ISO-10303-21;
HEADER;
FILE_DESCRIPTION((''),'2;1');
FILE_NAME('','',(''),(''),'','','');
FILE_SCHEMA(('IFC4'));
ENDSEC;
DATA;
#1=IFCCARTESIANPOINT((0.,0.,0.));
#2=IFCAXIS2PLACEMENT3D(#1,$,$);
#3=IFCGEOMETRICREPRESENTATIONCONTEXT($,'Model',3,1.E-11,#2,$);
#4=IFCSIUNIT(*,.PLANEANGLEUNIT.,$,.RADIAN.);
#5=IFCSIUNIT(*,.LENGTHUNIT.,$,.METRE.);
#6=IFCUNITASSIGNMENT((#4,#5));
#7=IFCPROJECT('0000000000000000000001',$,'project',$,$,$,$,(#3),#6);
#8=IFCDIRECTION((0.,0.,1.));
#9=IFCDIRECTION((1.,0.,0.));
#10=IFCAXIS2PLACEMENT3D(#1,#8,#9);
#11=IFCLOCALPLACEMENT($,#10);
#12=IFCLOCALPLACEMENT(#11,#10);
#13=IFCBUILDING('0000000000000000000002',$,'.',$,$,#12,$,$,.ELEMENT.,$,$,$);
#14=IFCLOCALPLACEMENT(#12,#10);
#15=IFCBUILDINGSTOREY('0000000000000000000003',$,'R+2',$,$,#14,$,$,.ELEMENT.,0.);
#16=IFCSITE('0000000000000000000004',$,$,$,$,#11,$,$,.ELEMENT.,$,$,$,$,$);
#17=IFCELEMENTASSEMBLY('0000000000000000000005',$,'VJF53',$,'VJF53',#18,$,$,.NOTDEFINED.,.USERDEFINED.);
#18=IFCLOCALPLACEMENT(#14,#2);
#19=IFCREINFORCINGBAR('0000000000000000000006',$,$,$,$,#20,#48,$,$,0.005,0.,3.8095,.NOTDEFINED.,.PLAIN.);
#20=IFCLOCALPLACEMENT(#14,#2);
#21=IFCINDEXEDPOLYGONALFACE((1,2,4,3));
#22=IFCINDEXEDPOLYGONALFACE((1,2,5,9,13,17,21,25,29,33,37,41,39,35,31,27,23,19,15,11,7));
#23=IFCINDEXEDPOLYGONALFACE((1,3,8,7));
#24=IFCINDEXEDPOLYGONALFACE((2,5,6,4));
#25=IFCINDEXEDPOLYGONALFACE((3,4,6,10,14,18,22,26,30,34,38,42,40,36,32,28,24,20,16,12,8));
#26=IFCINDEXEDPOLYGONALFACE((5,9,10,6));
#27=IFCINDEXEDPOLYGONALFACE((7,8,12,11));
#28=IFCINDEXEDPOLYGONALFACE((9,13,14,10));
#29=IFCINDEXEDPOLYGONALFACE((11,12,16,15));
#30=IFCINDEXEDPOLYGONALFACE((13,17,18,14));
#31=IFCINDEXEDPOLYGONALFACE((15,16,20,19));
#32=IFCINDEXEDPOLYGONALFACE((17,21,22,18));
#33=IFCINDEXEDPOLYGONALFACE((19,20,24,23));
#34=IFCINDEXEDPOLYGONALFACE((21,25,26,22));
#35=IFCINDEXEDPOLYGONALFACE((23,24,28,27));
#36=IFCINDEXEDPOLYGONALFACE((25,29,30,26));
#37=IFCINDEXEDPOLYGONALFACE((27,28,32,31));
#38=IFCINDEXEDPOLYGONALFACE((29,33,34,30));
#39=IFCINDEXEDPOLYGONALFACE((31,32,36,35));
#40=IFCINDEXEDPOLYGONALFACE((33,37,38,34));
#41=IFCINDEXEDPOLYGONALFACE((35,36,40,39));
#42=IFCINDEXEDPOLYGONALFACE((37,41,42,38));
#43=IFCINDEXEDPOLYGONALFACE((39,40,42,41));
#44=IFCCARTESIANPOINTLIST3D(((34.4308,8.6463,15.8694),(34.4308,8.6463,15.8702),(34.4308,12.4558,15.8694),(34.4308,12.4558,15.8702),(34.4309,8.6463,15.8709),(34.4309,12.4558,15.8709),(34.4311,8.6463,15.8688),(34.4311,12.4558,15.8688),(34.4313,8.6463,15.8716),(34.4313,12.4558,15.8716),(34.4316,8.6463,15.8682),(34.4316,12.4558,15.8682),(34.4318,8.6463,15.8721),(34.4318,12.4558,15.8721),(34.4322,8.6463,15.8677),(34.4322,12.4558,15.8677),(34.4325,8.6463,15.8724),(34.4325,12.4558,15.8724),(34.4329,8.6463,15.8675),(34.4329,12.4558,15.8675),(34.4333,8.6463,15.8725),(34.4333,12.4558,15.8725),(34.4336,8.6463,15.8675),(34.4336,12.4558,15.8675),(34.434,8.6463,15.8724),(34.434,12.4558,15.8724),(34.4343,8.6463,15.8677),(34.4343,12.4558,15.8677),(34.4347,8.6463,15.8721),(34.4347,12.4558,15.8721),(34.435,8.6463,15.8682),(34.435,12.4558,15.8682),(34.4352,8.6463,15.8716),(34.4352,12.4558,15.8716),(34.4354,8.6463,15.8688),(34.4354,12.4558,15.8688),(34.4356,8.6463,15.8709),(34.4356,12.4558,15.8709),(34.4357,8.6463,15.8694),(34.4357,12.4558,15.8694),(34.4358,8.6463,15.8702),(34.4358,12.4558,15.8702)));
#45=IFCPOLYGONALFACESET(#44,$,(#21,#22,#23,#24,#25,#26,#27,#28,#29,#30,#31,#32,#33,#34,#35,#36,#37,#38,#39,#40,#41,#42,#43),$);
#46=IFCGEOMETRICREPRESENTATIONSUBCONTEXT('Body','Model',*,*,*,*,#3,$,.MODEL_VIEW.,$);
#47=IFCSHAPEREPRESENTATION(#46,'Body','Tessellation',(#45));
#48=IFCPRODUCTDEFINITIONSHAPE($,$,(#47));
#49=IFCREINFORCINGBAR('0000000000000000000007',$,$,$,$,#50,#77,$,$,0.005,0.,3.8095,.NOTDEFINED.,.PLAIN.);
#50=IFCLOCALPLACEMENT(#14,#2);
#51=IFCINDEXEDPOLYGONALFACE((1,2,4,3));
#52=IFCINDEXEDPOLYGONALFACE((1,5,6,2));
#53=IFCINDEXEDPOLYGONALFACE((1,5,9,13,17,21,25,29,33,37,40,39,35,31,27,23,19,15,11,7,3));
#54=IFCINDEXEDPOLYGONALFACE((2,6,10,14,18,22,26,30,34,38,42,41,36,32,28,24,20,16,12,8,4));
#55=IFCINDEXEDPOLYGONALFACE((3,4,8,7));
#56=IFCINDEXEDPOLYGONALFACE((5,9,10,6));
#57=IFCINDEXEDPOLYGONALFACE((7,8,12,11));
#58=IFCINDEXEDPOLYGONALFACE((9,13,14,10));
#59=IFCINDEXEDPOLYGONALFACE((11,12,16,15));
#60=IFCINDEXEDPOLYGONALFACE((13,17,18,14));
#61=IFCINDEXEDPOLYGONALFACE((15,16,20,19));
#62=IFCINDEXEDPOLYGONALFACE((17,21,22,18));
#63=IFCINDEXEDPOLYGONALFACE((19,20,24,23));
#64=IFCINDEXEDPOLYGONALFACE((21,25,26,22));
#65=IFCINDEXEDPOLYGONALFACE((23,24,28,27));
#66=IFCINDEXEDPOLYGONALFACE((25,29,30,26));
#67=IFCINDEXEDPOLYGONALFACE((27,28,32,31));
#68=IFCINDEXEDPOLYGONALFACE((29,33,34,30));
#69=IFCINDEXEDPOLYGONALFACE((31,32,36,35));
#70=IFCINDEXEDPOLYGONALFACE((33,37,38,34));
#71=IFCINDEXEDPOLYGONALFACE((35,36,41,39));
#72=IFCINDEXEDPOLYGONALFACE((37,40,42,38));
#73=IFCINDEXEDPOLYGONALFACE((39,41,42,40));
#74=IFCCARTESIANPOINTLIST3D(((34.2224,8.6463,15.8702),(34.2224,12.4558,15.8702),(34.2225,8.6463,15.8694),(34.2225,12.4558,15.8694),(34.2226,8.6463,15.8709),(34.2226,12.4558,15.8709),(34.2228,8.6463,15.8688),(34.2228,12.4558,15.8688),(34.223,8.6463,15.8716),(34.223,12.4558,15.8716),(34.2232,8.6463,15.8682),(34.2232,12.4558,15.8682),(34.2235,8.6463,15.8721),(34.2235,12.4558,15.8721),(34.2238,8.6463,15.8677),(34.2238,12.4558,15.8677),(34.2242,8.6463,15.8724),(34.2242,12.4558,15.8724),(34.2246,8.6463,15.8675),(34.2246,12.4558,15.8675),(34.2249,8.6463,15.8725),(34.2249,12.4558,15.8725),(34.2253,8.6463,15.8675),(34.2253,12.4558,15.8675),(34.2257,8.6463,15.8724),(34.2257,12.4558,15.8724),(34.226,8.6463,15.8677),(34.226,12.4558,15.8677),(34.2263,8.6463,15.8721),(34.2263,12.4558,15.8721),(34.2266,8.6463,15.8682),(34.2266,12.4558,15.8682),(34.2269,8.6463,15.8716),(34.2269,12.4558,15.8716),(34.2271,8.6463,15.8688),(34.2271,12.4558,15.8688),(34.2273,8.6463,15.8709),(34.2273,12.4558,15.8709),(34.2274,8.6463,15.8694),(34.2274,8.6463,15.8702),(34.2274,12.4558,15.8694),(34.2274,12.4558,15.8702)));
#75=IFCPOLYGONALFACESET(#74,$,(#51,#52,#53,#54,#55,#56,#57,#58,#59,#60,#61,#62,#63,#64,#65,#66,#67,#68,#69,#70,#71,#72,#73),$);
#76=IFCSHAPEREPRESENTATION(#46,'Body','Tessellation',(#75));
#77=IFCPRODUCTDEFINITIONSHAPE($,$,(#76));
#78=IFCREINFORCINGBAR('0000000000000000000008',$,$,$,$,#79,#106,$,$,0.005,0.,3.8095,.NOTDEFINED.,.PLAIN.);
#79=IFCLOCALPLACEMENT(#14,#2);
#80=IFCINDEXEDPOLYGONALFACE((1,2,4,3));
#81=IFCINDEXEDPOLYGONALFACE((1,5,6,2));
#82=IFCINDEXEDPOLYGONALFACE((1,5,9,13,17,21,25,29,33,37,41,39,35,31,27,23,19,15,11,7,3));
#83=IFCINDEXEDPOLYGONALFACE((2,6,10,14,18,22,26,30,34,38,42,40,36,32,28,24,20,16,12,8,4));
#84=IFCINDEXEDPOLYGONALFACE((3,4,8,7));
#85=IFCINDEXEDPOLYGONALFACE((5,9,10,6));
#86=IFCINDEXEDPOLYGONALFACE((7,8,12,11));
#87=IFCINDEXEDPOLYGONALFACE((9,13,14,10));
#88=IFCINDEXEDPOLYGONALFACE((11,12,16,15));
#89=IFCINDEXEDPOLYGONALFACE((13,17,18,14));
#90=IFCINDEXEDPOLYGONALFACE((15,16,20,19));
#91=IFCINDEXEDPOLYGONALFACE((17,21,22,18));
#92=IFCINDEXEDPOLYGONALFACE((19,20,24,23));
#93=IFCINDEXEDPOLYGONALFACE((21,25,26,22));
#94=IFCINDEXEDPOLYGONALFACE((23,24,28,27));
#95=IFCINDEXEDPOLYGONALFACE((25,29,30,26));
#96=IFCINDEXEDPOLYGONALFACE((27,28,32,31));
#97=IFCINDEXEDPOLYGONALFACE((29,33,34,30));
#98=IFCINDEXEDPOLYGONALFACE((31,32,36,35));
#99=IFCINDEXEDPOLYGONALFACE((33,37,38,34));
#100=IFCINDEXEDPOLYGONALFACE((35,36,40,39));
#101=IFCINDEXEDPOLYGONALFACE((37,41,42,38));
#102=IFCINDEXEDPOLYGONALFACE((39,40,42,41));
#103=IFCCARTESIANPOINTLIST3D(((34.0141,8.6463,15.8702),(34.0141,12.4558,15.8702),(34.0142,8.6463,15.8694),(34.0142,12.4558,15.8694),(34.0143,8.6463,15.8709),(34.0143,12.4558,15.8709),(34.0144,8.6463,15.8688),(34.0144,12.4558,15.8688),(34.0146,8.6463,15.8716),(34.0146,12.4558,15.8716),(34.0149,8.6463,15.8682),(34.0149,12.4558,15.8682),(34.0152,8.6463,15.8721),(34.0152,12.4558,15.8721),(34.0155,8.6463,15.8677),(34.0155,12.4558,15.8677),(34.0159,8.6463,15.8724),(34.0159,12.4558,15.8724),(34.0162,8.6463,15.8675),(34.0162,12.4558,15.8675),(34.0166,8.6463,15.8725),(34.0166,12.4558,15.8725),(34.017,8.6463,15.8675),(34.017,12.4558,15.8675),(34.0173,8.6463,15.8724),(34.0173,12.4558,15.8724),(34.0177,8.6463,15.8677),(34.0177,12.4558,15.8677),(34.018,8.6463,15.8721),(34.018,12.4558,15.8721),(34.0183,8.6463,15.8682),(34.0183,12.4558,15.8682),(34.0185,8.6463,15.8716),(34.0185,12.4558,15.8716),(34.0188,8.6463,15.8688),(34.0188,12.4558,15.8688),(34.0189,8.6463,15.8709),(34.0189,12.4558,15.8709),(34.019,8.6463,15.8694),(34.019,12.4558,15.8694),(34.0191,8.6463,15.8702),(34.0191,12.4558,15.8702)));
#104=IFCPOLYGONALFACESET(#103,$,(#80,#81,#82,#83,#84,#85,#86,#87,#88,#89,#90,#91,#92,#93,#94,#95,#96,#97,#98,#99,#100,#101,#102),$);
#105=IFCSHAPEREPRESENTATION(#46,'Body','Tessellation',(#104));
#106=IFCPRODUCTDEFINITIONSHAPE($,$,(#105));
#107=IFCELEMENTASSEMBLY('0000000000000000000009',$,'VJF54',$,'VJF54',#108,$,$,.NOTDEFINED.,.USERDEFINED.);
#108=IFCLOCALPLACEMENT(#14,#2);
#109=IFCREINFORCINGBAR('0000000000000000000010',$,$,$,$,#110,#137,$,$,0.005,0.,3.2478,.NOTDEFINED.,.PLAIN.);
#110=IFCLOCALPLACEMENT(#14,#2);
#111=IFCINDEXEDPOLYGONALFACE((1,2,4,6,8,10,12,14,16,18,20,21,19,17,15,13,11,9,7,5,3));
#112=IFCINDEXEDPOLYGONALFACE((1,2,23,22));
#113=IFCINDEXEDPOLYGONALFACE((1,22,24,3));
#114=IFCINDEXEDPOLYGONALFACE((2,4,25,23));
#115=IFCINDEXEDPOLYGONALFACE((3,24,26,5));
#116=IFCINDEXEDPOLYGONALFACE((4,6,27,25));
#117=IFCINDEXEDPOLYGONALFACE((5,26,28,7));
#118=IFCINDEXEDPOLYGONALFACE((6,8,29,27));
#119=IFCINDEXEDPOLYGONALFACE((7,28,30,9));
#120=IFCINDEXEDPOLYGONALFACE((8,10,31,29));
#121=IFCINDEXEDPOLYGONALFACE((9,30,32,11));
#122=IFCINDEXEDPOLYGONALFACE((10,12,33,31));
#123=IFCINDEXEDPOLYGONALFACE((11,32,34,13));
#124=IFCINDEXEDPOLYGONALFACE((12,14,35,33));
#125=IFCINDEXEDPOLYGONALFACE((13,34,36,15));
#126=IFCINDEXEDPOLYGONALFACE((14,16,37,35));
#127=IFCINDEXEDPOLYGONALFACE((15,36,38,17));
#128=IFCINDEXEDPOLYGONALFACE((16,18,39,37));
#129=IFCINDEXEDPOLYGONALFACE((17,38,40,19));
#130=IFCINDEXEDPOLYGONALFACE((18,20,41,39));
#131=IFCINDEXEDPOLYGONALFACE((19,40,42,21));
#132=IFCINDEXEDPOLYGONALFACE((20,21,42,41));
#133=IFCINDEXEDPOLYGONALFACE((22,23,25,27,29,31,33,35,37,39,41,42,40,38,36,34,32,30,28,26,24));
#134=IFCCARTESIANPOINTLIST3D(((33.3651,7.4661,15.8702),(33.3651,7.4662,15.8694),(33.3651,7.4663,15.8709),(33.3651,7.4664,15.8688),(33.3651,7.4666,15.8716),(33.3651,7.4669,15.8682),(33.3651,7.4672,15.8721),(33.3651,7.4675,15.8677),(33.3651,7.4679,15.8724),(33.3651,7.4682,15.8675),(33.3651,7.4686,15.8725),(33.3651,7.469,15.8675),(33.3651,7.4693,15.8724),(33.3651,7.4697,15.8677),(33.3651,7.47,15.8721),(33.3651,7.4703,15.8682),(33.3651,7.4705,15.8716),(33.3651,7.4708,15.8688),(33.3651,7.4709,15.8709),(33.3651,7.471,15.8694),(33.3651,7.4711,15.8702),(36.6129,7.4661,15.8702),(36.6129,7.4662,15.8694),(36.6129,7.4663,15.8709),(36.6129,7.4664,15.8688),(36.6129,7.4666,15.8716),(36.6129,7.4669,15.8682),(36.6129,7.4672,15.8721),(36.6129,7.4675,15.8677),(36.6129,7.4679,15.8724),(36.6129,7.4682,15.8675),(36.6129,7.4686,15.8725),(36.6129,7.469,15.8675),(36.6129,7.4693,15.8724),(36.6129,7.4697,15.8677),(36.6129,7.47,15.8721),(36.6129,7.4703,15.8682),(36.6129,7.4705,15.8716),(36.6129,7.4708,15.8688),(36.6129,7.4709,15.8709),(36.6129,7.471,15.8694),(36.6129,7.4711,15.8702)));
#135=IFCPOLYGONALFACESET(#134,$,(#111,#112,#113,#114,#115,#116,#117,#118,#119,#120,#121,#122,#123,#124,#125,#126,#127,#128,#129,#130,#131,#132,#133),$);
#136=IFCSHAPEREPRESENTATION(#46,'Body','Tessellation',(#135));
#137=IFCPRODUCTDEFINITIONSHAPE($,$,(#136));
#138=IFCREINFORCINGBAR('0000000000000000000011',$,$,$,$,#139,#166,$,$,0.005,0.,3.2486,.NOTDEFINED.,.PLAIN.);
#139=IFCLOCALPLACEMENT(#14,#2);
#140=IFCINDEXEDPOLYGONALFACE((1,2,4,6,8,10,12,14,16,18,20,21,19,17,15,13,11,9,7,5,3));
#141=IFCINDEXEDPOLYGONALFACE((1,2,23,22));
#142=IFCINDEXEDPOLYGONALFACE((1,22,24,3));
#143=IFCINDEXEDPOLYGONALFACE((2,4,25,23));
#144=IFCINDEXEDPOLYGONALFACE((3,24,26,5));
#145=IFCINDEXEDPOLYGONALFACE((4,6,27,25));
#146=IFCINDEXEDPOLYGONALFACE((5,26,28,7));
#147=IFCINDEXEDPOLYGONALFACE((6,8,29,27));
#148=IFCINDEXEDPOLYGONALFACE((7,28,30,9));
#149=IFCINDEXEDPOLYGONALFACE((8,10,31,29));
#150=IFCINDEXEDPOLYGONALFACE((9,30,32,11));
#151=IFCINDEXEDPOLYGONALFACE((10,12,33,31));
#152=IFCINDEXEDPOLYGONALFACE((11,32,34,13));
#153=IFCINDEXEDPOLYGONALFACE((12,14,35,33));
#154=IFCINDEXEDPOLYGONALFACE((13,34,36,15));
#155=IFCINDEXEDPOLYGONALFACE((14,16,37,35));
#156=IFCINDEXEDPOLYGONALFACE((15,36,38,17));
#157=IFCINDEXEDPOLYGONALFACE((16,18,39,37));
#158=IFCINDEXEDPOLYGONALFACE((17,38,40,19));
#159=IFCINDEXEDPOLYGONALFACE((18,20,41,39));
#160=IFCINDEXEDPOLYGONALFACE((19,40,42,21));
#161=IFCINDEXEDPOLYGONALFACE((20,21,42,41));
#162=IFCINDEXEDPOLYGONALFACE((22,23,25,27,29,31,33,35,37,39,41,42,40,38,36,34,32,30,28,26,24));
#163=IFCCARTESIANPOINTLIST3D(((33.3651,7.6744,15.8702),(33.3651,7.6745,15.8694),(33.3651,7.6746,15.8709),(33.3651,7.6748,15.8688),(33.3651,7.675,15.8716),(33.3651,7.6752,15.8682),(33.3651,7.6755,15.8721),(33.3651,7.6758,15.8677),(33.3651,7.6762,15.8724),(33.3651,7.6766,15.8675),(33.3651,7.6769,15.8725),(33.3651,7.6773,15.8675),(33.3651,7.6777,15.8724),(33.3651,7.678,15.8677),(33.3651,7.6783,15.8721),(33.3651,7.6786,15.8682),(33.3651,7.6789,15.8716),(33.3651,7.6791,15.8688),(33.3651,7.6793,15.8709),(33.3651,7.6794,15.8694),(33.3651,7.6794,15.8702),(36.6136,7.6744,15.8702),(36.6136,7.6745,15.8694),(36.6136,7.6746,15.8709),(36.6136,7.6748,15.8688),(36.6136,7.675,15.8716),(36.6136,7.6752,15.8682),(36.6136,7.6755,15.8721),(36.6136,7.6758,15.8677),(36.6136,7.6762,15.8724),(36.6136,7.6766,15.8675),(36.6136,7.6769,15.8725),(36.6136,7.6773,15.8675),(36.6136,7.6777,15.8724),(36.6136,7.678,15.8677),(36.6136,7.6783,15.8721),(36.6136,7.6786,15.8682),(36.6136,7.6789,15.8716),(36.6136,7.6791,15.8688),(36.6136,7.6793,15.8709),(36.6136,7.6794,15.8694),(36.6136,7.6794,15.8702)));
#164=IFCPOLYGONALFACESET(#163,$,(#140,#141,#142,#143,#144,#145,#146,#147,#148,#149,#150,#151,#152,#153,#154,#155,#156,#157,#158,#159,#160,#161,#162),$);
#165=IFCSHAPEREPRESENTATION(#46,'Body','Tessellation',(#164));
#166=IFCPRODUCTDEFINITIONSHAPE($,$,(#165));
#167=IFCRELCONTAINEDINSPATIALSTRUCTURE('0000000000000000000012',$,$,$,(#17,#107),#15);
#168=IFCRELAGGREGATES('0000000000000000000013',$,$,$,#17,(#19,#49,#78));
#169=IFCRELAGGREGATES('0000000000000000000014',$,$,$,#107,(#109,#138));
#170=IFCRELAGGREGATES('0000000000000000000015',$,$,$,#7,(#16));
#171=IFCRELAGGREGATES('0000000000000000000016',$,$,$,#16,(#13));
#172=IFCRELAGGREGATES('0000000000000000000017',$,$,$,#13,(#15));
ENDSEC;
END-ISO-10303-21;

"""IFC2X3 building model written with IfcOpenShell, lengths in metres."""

from ifc_helpers import new_model, entity, si_unit, origin, origin_with_axes, place, context, subcontext, project, spatial, shape, element, aggregate, save


model = new_model("IFC2X3")

# Units and contexts
model_context = context("Model", 3, precision=1e-11, world=origin())
body_context = subcontext(model_context, "Body", "Model", "MODEL_VIEW")
ifc_project = project(units=[si_unit("PLANEANGLEUNIT", "RADIAN"), si_unit("LENGTHUNIT", "METRE")], contexts=[model_context])

# Site, building, storey
site_placement = place(None, origin_with_axes())
site = spatial("IfcSite", under=ifc_project, at=site_placement, CompositionType="ELEMENT")
building_placement = place(site_placement, origin_with_axes())
building = spatial("IfcBuilding", under=site, at=building_placement, Name=".", CompositionType="ELEMENT")
storey_placement = place(building_placement, origin_with_axes())
storey = spatial("IfcBuildingStorey", under=building, at=storey_placement, Name="R+2", CompositionType="ELEMENT", Elevation=0.0)

# Element assemblies, reinforcing bars
assembly_1_placement = place(storey_placement, origin_with_axes())
assembly_1 = element("IfcElementAssembly", 1, at=assembly_1_placement, inside=storey, Name="VJF53", ObjectType="VJF53", AssemblyPlace="NOTDEFINED", PredefinedType="USERDEFINED")
reinforcing_bar_1_placement = place(assembly_1_placement, origin_with_axes())
reinforcing_bar_1 = element("IfcReinforcingBar", 2, at=reinforcing_bar_1_placement, BarLength=3.8095, BarRole="NOTDEFINED", BarSurface="PLAIN", CrossSectionArea=0.0, NominalDiameter=0.005, shapes=[
    shape(body_context, "Body", "AdvancedSweptSolid", [entity("IfcSweptDiskSolid", entity("IfcPolyline", [entity("IfcCartesianPoint", [34.4333, 8.6463, 15.87]), entity("IfcCartesianPoint", [34.4333, 12.4558, 15.87])]), 0.0025, None, 0.0, 3.8095)]),
    shape(body_context, "Body", "AdvancedSweptSolid", [entity("IfcSweptDiskSolid", entity("IfcPolyline", [entity("IfcCartesianPoint", [34.4333, 8.6463, 15.87]), entity("IfcCartesianPoint", [34.4333, 12.4558, 15.87])]), 0.0025, None, 0.0, 3.8095)]),
])
reinforcing_bar_2_placement = place(assembly_1_placement, origin_with_axes())
reinforcing_bar_2 = element("IfcReinforcingBar", 3, at=reinforcing_bar_2_placement, BarLength=3.8095, BarRole="NOTDEFINED", BarSurface="PLAIN", CrossSectionArea=0.0, NominalDiameter=0.005, shapes=[
    shape(body_context, "Body", "AdvancedSweptSolid", [entity("IfcSweptDiskSolid", entity("IfcPolyline", [entity("IfcCartesianPoint", [34.2249, 8.6463, 15.87]), entity("IfcCartesianPoint", [34.2249, 12.4558, 15.87])]), 0.0025, None, 0.0, 3.8095)]),
    shape(body_context, "Body", "AdvancedSweptSolid", [entity("IfcSweptDiskSolid", entity("IfcPolyline", [entity("IfcCartesianPoint", [34.2249, 8.6463, 15.87]), entity("IfcCartesianPoint", [34.2249, 12.4558, 15.87])]), 0.0025, None, 0.0, 3.8095)]),
])
reinforcing_bar_3_placement = place(assembly_1_placement, origin_with_axes())
reinforcing_bar_3 = element("IfcReinforcingBar", 4, at=reinforcing_bar_3_placement, BarLength=3.8095, BarRole="NOTDEFINED", BarSurface="PLAIN", CrossSectionArea=0.0, NominalDiameter=0.005, shapes=[
    shape(body_context, "Body", "AdvancedSweptSolid", [entity("IfcSweptDiskSolid", entity("IfcPolyline", [entity("IfcCartesianPoint", [34.0166, 8.6463, 15.87]), entity("IfcCartesianPoint", [34.0166, 12.4558, 15.87])]), 0.0025, None, 0.0, 3.8095)]),
    shape(body_context, "Body", "AdvancedSweptSolid", [entity("IfcSweptDiskSolid", entity("IfcPolyline", [entity("IfcCartesianPoint", [34.0166, 8.6463, 15.87]), entity("IfcCartesianPoint", [34.0166, 12.4558, 15.87])]), 0.0025, None, 0.0, 3.8095)]),
])
aggregate(assembly_1, [reinforcing_bar_1, reinforcing_bar_2, reinforcing_bar_3])
assembly_2_placement = place(storey_placement, origin_with_axes())
assembly_2 = element("IfcElementAssembly", 5, at=assembly_2_placement, inside=storey, Name="VJF54", ObjectType="VJF54", AssemblyPlace="NOTDEFINED", PredefinedType="USERDEFINED")
reinforcing_bar_4_placement = place(assembly_2_placement, origin_with_axes())
reinforcing_bar_4 = element("IfcReinforcingBar", 6, at=reinforcing_bar_4_placement, BarLength=3.2478, BarRole="NOTDEFINED", BarSurface="PLAIN", CrossSectionArea=0.0, NominalDiameter=0.005, shapes=[
    shape(body_context, "Body", "AdvancedSweptSolid", [entity("IfcSweptDiskSolid", entity("IfcPolyline", [entity("IfcCartesianPoint", [33.3651, 7.4686, 15.87]), entity("IfcCartesianPoint", [36.6129, 7.4686, 15.87])]), 0.0025, None, 0.0, 3.2478)]),
    shape(body_context, "Body", "AdvancedSweptSolid", [entity("IfcSweptDiskSolid", entity("IfcPolyline", [entity("IfcCartesianPoint", [33.3651, 7.4686, 15.87]), entity("IfcCartesianPoint", [36.6129, 7.4686, 15.87])]), 0.0025, None, 0.0, 3.2478)]),
])
reinforcing_bar_5_placement = place(assembly_2_placement, origin_with_axes())
reinforcing_bar_5 = element("IfcReinforcingBar", 7, at=reinforcing_bar_5_placement, BarLength=3.2486, BarRole="NOTDEFINED", BarSurface="PLAIN", CrossSectionArea=0.0, NominalDiameter=0.005, shapes=[
    shape(body_context, "Body", "AdvancedSweptSolid", [entity("IfcSweptDiskSolid", entity("IfcPolyline", [entity("IfcCartesianPoint", [33.3651, 7.6769, 15.87]), entity("IfcCartesianPoint", [36.6136, 7.6769, 15.87])]), 0.0025, None, 0.0, 3.2486)]),
    shape(body_context, "Body", "AdvancedSweptSolid", [entity("IfcSweptDiskSolid", entity("IfcPolyline", [entity("IfcCartesianPoint", [33.3651, 7.6769, 15.87]), entity("IfcCartesianPoint", [36.6136, 7.6769, 15.87])]), 0.0025, None, 0.0, 3.2486)]),
])
aggregate(assembly_2, [reinforcing_bar_4, reinforcing_bar_5])

save(model, "model.ifc")
